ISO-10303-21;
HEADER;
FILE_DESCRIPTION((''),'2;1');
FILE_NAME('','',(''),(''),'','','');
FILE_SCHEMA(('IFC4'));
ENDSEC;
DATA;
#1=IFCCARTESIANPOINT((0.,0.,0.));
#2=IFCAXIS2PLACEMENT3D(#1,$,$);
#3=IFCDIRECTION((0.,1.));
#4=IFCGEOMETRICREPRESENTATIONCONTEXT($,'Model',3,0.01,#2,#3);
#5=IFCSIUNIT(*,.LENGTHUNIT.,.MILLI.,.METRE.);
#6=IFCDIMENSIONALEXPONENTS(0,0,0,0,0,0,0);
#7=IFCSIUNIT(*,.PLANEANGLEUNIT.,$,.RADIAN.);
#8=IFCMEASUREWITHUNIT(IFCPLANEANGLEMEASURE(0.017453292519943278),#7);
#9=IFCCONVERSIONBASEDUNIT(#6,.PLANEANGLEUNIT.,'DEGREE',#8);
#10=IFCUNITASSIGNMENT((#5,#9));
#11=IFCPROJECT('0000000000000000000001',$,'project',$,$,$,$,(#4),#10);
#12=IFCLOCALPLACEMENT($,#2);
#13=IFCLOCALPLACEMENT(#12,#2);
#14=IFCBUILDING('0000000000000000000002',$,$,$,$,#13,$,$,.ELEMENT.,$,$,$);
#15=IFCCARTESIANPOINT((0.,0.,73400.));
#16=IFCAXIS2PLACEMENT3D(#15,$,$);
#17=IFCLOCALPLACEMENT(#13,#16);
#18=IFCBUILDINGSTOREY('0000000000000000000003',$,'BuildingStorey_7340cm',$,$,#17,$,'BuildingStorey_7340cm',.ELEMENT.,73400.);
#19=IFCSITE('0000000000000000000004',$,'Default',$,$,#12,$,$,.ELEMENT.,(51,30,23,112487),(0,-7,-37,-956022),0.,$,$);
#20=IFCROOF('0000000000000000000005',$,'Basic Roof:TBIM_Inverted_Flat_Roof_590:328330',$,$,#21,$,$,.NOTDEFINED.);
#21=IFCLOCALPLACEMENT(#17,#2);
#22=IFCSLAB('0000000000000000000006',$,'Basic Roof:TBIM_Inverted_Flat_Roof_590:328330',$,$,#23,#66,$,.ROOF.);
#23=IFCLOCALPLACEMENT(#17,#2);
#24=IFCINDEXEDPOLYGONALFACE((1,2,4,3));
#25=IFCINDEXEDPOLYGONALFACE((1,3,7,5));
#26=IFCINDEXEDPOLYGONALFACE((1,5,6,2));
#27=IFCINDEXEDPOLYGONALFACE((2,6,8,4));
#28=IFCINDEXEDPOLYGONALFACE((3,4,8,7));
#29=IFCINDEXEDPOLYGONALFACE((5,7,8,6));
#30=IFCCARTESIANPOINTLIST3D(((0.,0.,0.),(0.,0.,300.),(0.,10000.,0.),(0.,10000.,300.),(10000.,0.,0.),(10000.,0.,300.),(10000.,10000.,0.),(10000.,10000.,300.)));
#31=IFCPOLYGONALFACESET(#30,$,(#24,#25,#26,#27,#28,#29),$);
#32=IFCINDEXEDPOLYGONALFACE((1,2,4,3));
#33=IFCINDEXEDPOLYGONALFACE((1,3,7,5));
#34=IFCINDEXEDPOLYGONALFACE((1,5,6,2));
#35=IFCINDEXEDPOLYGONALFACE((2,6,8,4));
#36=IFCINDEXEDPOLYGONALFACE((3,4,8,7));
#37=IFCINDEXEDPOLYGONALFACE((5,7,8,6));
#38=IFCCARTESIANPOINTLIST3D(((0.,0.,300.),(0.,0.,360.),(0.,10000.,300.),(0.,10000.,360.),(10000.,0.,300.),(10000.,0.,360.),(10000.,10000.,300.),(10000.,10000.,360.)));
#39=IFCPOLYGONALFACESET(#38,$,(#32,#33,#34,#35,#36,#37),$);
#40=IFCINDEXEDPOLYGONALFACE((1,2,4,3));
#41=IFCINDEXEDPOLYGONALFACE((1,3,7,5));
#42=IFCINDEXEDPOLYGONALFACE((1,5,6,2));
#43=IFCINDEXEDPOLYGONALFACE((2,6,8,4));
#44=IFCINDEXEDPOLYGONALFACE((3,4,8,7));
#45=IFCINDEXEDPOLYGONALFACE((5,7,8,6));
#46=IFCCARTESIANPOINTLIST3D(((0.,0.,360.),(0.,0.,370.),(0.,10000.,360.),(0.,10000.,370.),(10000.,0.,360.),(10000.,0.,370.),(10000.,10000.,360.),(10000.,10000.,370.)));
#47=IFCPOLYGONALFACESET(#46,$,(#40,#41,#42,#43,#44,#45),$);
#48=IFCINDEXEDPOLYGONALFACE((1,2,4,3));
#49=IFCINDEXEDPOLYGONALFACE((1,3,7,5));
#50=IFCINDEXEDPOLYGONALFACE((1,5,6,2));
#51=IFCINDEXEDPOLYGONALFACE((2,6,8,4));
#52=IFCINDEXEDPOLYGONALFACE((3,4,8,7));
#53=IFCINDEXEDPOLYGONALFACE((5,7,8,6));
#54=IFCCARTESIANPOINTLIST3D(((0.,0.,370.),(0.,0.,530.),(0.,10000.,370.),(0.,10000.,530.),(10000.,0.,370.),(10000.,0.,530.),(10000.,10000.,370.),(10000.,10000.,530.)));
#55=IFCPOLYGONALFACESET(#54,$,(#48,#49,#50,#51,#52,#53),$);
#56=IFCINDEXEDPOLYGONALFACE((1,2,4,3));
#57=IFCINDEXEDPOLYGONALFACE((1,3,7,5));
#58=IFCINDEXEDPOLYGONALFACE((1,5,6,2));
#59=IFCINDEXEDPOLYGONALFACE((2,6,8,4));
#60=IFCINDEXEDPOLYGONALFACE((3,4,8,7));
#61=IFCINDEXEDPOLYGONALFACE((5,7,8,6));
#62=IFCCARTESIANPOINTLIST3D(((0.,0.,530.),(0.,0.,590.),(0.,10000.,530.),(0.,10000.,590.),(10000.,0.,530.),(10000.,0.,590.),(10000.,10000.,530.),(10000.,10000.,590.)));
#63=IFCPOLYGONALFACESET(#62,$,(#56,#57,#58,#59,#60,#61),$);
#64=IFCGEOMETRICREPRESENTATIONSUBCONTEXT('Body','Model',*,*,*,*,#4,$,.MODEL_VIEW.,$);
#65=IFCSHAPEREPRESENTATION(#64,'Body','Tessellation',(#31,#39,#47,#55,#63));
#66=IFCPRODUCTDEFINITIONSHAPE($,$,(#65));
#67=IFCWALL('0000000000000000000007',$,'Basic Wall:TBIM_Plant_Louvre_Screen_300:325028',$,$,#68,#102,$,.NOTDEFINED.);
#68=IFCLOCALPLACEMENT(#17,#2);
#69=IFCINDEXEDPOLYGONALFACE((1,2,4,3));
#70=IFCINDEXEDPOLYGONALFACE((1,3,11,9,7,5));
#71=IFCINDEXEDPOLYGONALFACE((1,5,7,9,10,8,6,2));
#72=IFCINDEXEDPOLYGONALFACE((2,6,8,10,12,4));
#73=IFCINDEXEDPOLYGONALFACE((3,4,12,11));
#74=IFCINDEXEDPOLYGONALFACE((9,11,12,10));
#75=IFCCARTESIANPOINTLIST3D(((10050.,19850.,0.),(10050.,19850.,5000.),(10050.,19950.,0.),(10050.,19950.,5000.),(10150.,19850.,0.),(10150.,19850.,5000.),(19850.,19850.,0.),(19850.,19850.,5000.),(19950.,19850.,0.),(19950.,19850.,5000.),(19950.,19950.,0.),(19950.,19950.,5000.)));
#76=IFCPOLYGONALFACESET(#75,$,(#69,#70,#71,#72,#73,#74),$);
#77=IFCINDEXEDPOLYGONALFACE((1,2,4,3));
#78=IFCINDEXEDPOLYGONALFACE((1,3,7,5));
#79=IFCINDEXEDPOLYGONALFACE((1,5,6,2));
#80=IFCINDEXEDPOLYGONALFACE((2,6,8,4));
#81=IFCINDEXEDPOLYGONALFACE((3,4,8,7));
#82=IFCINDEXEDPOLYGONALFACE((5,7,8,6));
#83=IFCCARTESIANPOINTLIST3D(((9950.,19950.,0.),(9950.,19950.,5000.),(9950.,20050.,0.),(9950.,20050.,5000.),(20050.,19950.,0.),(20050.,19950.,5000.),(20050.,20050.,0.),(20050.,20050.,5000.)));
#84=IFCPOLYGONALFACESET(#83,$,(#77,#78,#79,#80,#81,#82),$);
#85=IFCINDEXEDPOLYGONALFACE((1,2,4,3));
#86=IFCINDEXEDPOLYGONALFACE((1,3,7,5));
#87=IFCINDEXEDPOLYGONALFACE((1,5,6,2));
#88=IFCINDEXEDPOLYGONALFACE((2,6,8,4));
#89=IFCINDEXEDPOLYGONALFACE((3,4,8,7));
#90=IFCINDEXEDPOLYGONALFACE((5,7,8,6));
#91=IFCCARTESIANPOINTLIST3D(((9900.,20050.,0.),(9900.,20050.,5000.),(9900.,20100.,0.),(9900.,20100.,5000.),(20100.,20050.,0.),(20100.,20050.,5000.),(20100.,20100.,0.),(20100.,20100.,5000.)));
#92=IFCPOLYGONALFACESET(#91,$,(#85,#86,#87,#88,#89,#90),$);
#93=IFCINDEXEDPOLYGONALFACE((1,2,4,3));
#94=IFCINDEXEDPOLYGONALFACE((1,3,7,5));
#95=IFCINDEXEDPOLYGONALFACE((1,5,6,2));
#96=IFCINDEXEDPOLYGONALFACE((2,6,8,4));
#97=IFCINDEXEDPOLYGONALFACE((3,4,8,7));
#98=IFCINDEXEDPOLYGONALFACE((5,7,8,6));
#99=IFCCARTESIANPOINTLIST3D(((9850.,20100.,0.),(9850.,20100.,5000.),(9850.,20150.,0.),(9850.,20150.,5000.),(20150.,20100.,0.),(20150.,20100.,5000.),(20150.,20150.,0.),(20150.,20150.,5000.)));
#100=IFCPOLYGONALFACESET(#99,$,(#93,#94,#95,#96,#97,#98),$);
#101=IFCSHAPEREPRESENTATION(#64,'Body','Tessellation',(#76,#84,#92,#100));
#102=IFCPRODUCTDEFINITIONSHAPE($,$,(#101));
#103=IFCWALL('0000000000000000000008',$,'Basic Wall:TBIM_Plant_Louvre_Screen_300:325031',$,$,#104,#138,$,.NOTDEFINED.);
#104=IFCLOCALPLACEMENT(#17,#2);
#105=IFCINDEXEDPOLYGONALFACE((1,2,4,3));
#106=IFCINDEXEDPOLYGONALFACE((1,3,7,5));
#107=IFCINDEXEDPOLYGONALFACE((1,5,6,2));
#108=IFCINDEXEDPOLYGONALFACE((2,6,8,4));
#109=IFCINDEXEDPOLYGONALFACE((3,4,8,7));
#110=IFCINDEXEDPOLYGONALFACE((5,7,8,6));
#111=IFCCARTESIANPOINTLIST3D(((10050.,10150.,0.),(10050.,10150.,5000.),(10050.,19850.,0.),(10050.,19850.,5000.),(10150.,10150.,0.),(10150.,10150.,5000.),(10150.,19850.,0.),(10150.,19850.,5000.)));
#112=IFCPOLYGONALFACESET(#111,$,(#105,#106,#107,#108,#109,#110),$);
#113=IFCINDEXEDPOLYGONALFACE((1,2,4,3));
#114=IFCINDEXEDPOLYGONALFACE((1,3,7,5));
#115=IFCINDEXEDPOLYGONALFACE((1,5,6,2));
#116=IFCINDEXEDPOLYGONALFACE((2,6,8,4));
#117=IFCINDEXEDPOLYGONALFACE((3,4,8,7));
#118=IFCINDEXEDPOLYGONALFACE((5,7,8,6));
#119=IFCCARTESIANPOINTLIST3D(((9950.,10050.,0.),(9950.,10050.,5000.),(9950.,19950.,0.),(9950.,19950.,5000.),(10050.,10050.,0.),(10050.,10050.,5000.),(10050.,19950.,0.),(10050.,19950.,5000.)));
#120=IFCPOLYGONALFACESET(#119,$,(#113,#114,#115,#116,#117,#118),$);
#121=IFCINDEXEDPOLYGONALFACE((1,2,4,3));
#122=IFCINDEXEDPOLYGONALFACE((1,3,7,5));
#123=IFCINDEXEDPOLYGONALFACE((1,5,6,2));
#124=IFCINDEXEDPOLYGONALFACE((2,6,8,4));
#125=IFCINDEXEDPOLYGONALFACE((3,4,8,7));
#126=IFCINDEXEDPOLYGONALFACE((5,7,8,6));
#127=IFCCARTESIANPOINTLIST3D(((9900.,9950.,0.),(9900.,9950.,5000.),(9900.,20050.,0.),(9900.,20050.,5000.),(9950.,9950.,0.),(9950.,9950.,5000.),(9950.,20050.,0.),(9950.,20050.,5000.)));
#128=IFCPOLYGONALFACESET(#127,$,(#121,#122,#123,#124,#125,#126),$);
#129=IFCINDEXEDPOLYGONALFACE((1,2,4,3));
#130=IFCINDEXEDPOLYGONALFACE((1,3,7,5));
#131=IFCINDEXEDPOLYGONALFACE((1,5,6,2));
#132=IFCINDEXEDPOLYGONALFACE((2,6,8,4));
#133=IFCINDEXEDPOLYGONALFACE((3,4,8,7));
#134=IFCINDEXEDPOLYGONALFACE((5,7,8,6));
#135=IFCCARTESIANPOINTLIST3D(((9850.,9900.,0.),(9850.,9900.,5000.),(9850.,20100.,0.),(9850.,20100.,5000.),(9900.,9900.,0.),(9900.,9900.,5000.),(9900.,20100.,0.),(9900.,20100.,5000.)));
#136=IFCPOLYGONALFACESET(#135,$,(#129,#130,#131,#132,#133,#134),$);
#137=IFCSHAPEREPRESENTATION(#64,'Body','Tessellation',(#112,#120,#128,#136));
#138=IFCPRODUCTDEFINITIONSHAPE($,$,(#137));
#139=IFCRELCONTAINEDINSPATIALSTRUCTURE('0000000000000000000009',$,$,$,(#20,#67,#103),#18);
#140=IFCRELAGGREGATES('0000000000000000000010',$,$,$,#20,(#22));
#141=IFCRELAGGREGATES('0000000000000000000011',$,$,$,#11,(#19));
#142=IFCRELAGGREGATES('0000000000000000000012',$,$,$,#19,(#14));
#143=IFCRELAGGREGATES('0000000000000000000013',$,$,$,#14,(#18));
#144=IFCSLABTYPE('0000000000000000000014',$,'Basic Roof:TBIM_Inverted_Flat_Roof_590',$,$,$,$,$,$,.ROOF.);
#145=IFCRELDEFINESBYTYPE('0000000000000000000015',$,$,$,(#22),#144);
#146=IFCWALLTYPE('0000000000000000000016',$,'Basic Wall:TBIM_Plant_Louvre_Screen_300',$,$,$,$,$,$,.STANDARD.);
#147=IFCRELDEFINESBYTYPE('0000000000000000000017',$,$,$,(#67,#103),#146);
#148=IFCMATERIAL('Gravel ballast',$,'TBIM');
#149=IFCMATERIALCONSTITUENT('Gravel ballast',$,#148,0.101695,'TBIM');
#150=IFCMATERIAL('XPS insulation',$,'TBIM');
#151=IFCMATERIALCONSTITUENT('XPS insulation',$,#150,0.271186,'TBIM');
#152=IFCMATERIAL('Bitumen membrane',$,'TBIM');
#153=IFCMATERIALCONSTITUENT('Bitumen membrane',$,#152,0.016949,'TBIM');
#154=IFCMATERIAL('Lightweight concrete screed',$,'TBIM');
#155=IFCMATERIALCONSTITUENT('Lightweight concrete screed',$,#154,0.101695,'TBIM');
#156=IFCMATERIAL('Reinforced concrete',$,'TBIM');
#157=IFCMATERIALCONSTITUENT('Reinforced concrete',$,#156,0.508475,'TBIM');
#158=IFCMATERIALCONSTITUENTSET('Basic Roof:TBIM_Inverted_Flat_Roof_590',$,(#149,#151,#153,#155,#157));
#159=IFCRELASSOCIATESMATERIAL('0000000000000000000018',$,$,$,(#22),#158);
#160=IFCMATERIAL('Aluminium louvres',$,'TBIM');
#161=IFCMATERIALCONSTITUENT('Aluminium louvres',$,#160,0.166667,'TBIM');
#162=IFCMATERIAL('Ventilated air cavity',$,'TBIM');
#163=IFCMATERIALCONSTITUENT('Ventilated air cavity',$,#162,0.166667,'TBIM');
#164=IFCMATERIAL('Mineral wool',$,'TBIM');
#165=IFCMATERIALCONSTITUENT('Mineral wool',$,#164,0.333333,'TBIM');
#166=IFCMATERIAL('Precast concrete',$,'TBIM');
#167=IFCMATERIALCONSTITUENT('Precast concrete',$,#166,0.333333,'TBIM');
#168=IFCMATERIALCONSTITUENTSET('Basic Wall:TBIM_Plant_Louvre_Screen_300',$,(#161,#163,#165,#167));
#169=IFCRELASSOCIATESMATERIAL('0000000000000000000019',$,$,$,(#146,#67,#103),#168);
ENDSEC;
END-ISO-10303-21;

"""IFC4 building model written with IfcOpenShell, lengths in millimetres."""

from ifc_helpers import new_model, entity, si_unit, converted_unit, direction, frame, origin, place, context, subcontext, project, spatial, indexed_curve, outline, extrude, material, constituent, constituent_set, type_object, element, aggregate, save


model = new_model("IFC4")

# Units and contexts
model_context = context("Model", 3, precision=0.01, world=origin(), true_north=direction((0.0, 1.0)))
body_context = subcontext(model_context, "Body", "Model", "MODEL_VIEW")
ifc_project = project(units=[si_unit("LENGTHUNIT", "METRE", prefix="MILLI"), converted_unit("PLANEANGLEUNIT", "DEGREE", entity("IfcPlaneAngleMeasure", 0.017453292519943278), si_unit("PLANEANGLEUNIT", "RADIAN"), dimensions=[0, 0, 0, 0, 0, 0, 0])], contexts=[model_context])

# Site, building, storey
site_placement = place(None, origin())
site = spatial("IfcSite", under=ifc_project, at=site_placement, Name="Default", CompositionType="ELEMENT", RefLatitude=(51, 30, 23, 112487), RefLongitude=(0, -7, -37, -956022), RefElevation=0.0)
building_placement = place(site_placement, origin())
building = spatial("IfcBuilding", under=site, at=building_placement, CompositionType="ELEMENT")
storey_placement = place(building_placement, frame((0.0, 0.0, 73400.0)))
storey = spatial("IfcBuildingStorey", under=building, at=storey_placement, Name="BuildingStorey_7340cm", LongName="BuildingStorey_7340cm", CompositionType="ELEMENT", Elevation=73400.0)

# Shared definitions
ifc_material_1 = material(Name="Reinforced concrete", Category="TBIM")

# Roof, slab
ifc_material_2 = material(Name="Gravel ballast", Category="TBIM")
ifc_constituent_1 = constituent(ifc_material_2, Name="Gravel ballast", Category="TBIM", fraction=0.101695)
ifc_material_3 = material(Name="XPS insulation", Category="TBIM")
ifc_constituent_2 = constituent(ifc_material_3, Name="XPS insulation", Category="TBIM", fraction=0.271186)
ifc_material_4 = material(Name="Bitumen membrane", Category="TBIM")
ifc_constituent_3 = constituent(ifc_material_4, Name="Bitumen membrane", Category="TBIM", fraction=0.016949)
ifc_material_5 = material(Name="Lightweight concrete screed", Category="TBIM")
ifc_constituent_4 = constituent(ifc_material_5, Name="Lightweight concrete screed", Category="TBIM", fraction=0.101695)
ifc_constituent_5 = constituent(ifc_material_1, Name="Reinforced concrete", Category="TBIM", fraction=0.508475)
ifc_constituent_set_1 = constituent_set(constituents=[ifc_constituent_1, ifc_constituent_2, ifc_constituent_3, ifc_constituent_4, ifc_constituent_5], Name="Basic Roof:TBIM_Inverted_Flat_Roof_590")
slab_type_1 = type_object("IfcSlabType", Name="Basic Roof:TBIM_Inverted_Flat_Roof_590", PredefinedType="ROOF")
roof_1_placement = place(storey_placement, origin())
roof_1 = element("IfcRoof", 1, at=roof_1_placement, inside=storey, Name="Basic Roof:TBIM_Inverted_Flat_Roof_590:328330", PredefinedType="NOTDEFINED")
slab_1_placement = place(roof_1_placement, origin())
slab_1 = element("IfcSlab", 2, at=slab_1_placement, type_object=slab_type_1, material=ifc_constituent_set_1, Name="Basic Roof:TBIM_Inverted_Flat_Roof_590:328330", PredefinedType="ROOF", context=body_context, shape_type="SweptSolid", body=[
    extrude(outline(indexed_curve([(-5000.0, 5000.0), (-5000.0, -5000.0), (5000.0, -5000.0), (5000.0, 5000.0), (-5000.0, 5000.0)], self_intersect=False)), frame((5000.0, 5000.0, 0.0)), (0.0, 0.0, 1.0), 300.0),
    extrude(outline(indexed_curve([(-5000.0, 5000.0), (-5000.0, -5000.0), (5000.0, -5000.0), (5000.0, 5000.0), (-5000.0, 5000.0)], self_intersect=False)), frame((5000.0, 5000.0, 300.0)), (0.0, 0.0, 1.0), 60.0),
    extrude(outline(indexed_curve([(-5000.0, 5000.0), (-5000.0, -5000.0), (5000.0, -5000.0), (5000.0, 5000.0), (-5000.0, 5000.0)], self_intersect=False)), frame((5000.0, 5000.0, 360.0)), (0.0, 0.0, 1.0), 10.0),
    extrude(outline(indexed_curve([(-5000.0, 5000.0), (-5000.0, -5000.0), (5000.0, -5000.0), (5000.0, 5000.0), (-5000.0, 5000.0)], self_intersect=False)), frame((5000.0, 5000.0, 370.0)), (0.0, 0.0, 1.0), 160.0),
    extrude(outline(indexed_curve([(-5000.0, 5000.0), (-5000.0, -5000.0), (5000.0, -5000.0), (5000.0, 5000.0), (-5000.0, 5000.0)], self_intersect=False)), frame((5000.0, 5000.0, 530.0)), (0.0, 0.0, 1.0), 60.0),
])
aggregate(roof_1, [slab_1])

# Walls
ifc_material_6 = material(Name="Aluminium louvres", Category="TBIM")
ifc_constituent_6 = constituent(ifc_material_6, Name="Aluminium louvres", Category="TBIM", fraction=0.166667)
ifc_material_7 = material(Name="Ventilated air cavity", Category="TBIM")
ifc_constituent_7 = constituent(ifc_material_7, Name="Ventilated air cavity", Category="TBIM", fraction=0.166667)
ifc_material_8 = material(Name="Mineral wool", Category="TBIM")
ifc_constituent_8 = constituent(ifc_material_8, Name="Mineral wool", Category="TBIM", fraction=0.333333)
ifc_material_9 = material(Name="Precast concrete", Category="TBIM")
ifc_constituent_9 = constituent(ifc_material_9, Name="Precast concrete", Category="TBIM", fraction=0.333333)
ifc_constituent_set_2 = constituent_set(constituents=[ifc_constituent_6, ifc_constituent_7, ifc_constituent_8, ifc_constituent_9], Name="Basic Wall:TBIM_Plant_Louvre_Screen_300")
wall_type = type_object("IfcWallType", Name="Basic Wall:TBIM_Plant_Louvre_Screen_300", PredefinedType="STANDARD", material=ifc_constituent_set_2)
wall_1_placement = place(storey_placement, frame((9850.0, 20000.0, 0.0)))
element("IfcWall", 3, at=wall_1_placement, inside=storey, type_object=wall_type, material=ifc_constituent_set_2, Name="Basic Wall:TBIM_Plant_Louvre_Screen_300:325028", PredefinedType="NOTDEFINED", context=body_context, shape_type="SweptSolid", body=[
    extrude(outline(indexed_curve([(-4850.0, -33.3), (4850.0, -33.3), (4950.0, -33.3), (4950.0, 66.7), (-4950.0, 66.7), (-4950.0, -33.3), (-4850.0, -33.3)], self_intersect=False)), frame((5150.0, -116.7, 0.0)), (0.0, 0.0, 1.0), 5000.0),
    extrude(outline(indexed_curve([(-5050.0, -50.0), (5050.0, -50.0), (5050.0, 50.0), (-5050.0, 50.0), (-5050.0, -50.0)], self_intersect=False)), frame((5150.0, 0.0, 0.0)), (0.0, 0.0, 1.0), 5000.0),
    extrude(outline(indexed_curve([(-5100.0, -25.0), (5100.0, -25.0), (5100.0, 25.0), (-5100.0, 25.0), (-5100.0, -25.0)], self_intersect=False)), frame((5150.0, 75.0, 0.0)), (0.0, 0.0, 1.0), 5000.0),
    extrude(outline(indexed_curve([(-25.0, -5150.0), (25.0, -5150.0), (25.0, 5150.0), (-25.0, 5150.0), (-25.0, -5150.0)], self_intersect=False)), frame((5150.0, 125.0, 0.0), z_axis=(0.0, 0.0, 1.0), x_axis=(0.0, -1.0, 0.0)), (0.0, 0.0, 1.0), 5000.0),
])
wall_2_placement = place(storey_placement, frame((10000.0, 10150.0, 0.0), z_axis=(0.0, 0.0, 1.0), x_axis=(0.0, 1.0, 0.0)))
element("IfcWall", 4, at=wall_2_placement, inside=storey, type_object=wall_type, material=ifc_constituent_set_2, Name="Basic Wall:TBIM_Plant_Louvre_Screen_300:325031", PredefinedType="NOTDEFINED", context=body_context, shape_type="SweptSolid", body=[
    extrude(outline(indexed_curve([(-50.0, -4850.0), (50.0, -4850.0), (50.0, 4850.0), (-50.0, 4850.0), (-50.0, -4850.0)], self_intersect=False)), frame((4850.0, -100.0, 0.0), z_axis=(0.0, 0.0, 1.0), x_axis=(0.0, 1.0, 0.0)), (0.0, 0.0, 1.0), 5000.0),
    extrude(outline(indexed_curve([(-4950.0, -50.0), (4950.0, -50.0), (4950.0, 50.0), (-4950.0, 50.0), (-4950.0, -50.0)], self_intersect=False)), frame((4850.0, 0.0, 0.0)), (0.0, 0.0, 1.0), 5000.0),
    extrude(outline(indexed_curve([(-5050.0, -25.0), (5050.0, -25.0), (5050.0, 25.0), (-5050.0, 25.0), (-5050.0, -25.0)], self_intersect=False)), frame((4850.0, 75.0, 0.0)), (0.0, 0.0, 1.0), 5000.0),
    extrude(outline(indexed_curve([(-25.0, -5100.0), (25.0, -5100.0), (25.0, 5100.0), (-25.0, 5100.0), (-25.0, -5100.0)], self_intersect=False)), frame((4850.0, 125.0, 0.0), z_axis=(0.0, 0.0, 1.0), x_axis=(0.0, -1.0, 0.0)), (0.0, 0.0, 1.0), 5000.0),
])

save(model, "model.ifc")
